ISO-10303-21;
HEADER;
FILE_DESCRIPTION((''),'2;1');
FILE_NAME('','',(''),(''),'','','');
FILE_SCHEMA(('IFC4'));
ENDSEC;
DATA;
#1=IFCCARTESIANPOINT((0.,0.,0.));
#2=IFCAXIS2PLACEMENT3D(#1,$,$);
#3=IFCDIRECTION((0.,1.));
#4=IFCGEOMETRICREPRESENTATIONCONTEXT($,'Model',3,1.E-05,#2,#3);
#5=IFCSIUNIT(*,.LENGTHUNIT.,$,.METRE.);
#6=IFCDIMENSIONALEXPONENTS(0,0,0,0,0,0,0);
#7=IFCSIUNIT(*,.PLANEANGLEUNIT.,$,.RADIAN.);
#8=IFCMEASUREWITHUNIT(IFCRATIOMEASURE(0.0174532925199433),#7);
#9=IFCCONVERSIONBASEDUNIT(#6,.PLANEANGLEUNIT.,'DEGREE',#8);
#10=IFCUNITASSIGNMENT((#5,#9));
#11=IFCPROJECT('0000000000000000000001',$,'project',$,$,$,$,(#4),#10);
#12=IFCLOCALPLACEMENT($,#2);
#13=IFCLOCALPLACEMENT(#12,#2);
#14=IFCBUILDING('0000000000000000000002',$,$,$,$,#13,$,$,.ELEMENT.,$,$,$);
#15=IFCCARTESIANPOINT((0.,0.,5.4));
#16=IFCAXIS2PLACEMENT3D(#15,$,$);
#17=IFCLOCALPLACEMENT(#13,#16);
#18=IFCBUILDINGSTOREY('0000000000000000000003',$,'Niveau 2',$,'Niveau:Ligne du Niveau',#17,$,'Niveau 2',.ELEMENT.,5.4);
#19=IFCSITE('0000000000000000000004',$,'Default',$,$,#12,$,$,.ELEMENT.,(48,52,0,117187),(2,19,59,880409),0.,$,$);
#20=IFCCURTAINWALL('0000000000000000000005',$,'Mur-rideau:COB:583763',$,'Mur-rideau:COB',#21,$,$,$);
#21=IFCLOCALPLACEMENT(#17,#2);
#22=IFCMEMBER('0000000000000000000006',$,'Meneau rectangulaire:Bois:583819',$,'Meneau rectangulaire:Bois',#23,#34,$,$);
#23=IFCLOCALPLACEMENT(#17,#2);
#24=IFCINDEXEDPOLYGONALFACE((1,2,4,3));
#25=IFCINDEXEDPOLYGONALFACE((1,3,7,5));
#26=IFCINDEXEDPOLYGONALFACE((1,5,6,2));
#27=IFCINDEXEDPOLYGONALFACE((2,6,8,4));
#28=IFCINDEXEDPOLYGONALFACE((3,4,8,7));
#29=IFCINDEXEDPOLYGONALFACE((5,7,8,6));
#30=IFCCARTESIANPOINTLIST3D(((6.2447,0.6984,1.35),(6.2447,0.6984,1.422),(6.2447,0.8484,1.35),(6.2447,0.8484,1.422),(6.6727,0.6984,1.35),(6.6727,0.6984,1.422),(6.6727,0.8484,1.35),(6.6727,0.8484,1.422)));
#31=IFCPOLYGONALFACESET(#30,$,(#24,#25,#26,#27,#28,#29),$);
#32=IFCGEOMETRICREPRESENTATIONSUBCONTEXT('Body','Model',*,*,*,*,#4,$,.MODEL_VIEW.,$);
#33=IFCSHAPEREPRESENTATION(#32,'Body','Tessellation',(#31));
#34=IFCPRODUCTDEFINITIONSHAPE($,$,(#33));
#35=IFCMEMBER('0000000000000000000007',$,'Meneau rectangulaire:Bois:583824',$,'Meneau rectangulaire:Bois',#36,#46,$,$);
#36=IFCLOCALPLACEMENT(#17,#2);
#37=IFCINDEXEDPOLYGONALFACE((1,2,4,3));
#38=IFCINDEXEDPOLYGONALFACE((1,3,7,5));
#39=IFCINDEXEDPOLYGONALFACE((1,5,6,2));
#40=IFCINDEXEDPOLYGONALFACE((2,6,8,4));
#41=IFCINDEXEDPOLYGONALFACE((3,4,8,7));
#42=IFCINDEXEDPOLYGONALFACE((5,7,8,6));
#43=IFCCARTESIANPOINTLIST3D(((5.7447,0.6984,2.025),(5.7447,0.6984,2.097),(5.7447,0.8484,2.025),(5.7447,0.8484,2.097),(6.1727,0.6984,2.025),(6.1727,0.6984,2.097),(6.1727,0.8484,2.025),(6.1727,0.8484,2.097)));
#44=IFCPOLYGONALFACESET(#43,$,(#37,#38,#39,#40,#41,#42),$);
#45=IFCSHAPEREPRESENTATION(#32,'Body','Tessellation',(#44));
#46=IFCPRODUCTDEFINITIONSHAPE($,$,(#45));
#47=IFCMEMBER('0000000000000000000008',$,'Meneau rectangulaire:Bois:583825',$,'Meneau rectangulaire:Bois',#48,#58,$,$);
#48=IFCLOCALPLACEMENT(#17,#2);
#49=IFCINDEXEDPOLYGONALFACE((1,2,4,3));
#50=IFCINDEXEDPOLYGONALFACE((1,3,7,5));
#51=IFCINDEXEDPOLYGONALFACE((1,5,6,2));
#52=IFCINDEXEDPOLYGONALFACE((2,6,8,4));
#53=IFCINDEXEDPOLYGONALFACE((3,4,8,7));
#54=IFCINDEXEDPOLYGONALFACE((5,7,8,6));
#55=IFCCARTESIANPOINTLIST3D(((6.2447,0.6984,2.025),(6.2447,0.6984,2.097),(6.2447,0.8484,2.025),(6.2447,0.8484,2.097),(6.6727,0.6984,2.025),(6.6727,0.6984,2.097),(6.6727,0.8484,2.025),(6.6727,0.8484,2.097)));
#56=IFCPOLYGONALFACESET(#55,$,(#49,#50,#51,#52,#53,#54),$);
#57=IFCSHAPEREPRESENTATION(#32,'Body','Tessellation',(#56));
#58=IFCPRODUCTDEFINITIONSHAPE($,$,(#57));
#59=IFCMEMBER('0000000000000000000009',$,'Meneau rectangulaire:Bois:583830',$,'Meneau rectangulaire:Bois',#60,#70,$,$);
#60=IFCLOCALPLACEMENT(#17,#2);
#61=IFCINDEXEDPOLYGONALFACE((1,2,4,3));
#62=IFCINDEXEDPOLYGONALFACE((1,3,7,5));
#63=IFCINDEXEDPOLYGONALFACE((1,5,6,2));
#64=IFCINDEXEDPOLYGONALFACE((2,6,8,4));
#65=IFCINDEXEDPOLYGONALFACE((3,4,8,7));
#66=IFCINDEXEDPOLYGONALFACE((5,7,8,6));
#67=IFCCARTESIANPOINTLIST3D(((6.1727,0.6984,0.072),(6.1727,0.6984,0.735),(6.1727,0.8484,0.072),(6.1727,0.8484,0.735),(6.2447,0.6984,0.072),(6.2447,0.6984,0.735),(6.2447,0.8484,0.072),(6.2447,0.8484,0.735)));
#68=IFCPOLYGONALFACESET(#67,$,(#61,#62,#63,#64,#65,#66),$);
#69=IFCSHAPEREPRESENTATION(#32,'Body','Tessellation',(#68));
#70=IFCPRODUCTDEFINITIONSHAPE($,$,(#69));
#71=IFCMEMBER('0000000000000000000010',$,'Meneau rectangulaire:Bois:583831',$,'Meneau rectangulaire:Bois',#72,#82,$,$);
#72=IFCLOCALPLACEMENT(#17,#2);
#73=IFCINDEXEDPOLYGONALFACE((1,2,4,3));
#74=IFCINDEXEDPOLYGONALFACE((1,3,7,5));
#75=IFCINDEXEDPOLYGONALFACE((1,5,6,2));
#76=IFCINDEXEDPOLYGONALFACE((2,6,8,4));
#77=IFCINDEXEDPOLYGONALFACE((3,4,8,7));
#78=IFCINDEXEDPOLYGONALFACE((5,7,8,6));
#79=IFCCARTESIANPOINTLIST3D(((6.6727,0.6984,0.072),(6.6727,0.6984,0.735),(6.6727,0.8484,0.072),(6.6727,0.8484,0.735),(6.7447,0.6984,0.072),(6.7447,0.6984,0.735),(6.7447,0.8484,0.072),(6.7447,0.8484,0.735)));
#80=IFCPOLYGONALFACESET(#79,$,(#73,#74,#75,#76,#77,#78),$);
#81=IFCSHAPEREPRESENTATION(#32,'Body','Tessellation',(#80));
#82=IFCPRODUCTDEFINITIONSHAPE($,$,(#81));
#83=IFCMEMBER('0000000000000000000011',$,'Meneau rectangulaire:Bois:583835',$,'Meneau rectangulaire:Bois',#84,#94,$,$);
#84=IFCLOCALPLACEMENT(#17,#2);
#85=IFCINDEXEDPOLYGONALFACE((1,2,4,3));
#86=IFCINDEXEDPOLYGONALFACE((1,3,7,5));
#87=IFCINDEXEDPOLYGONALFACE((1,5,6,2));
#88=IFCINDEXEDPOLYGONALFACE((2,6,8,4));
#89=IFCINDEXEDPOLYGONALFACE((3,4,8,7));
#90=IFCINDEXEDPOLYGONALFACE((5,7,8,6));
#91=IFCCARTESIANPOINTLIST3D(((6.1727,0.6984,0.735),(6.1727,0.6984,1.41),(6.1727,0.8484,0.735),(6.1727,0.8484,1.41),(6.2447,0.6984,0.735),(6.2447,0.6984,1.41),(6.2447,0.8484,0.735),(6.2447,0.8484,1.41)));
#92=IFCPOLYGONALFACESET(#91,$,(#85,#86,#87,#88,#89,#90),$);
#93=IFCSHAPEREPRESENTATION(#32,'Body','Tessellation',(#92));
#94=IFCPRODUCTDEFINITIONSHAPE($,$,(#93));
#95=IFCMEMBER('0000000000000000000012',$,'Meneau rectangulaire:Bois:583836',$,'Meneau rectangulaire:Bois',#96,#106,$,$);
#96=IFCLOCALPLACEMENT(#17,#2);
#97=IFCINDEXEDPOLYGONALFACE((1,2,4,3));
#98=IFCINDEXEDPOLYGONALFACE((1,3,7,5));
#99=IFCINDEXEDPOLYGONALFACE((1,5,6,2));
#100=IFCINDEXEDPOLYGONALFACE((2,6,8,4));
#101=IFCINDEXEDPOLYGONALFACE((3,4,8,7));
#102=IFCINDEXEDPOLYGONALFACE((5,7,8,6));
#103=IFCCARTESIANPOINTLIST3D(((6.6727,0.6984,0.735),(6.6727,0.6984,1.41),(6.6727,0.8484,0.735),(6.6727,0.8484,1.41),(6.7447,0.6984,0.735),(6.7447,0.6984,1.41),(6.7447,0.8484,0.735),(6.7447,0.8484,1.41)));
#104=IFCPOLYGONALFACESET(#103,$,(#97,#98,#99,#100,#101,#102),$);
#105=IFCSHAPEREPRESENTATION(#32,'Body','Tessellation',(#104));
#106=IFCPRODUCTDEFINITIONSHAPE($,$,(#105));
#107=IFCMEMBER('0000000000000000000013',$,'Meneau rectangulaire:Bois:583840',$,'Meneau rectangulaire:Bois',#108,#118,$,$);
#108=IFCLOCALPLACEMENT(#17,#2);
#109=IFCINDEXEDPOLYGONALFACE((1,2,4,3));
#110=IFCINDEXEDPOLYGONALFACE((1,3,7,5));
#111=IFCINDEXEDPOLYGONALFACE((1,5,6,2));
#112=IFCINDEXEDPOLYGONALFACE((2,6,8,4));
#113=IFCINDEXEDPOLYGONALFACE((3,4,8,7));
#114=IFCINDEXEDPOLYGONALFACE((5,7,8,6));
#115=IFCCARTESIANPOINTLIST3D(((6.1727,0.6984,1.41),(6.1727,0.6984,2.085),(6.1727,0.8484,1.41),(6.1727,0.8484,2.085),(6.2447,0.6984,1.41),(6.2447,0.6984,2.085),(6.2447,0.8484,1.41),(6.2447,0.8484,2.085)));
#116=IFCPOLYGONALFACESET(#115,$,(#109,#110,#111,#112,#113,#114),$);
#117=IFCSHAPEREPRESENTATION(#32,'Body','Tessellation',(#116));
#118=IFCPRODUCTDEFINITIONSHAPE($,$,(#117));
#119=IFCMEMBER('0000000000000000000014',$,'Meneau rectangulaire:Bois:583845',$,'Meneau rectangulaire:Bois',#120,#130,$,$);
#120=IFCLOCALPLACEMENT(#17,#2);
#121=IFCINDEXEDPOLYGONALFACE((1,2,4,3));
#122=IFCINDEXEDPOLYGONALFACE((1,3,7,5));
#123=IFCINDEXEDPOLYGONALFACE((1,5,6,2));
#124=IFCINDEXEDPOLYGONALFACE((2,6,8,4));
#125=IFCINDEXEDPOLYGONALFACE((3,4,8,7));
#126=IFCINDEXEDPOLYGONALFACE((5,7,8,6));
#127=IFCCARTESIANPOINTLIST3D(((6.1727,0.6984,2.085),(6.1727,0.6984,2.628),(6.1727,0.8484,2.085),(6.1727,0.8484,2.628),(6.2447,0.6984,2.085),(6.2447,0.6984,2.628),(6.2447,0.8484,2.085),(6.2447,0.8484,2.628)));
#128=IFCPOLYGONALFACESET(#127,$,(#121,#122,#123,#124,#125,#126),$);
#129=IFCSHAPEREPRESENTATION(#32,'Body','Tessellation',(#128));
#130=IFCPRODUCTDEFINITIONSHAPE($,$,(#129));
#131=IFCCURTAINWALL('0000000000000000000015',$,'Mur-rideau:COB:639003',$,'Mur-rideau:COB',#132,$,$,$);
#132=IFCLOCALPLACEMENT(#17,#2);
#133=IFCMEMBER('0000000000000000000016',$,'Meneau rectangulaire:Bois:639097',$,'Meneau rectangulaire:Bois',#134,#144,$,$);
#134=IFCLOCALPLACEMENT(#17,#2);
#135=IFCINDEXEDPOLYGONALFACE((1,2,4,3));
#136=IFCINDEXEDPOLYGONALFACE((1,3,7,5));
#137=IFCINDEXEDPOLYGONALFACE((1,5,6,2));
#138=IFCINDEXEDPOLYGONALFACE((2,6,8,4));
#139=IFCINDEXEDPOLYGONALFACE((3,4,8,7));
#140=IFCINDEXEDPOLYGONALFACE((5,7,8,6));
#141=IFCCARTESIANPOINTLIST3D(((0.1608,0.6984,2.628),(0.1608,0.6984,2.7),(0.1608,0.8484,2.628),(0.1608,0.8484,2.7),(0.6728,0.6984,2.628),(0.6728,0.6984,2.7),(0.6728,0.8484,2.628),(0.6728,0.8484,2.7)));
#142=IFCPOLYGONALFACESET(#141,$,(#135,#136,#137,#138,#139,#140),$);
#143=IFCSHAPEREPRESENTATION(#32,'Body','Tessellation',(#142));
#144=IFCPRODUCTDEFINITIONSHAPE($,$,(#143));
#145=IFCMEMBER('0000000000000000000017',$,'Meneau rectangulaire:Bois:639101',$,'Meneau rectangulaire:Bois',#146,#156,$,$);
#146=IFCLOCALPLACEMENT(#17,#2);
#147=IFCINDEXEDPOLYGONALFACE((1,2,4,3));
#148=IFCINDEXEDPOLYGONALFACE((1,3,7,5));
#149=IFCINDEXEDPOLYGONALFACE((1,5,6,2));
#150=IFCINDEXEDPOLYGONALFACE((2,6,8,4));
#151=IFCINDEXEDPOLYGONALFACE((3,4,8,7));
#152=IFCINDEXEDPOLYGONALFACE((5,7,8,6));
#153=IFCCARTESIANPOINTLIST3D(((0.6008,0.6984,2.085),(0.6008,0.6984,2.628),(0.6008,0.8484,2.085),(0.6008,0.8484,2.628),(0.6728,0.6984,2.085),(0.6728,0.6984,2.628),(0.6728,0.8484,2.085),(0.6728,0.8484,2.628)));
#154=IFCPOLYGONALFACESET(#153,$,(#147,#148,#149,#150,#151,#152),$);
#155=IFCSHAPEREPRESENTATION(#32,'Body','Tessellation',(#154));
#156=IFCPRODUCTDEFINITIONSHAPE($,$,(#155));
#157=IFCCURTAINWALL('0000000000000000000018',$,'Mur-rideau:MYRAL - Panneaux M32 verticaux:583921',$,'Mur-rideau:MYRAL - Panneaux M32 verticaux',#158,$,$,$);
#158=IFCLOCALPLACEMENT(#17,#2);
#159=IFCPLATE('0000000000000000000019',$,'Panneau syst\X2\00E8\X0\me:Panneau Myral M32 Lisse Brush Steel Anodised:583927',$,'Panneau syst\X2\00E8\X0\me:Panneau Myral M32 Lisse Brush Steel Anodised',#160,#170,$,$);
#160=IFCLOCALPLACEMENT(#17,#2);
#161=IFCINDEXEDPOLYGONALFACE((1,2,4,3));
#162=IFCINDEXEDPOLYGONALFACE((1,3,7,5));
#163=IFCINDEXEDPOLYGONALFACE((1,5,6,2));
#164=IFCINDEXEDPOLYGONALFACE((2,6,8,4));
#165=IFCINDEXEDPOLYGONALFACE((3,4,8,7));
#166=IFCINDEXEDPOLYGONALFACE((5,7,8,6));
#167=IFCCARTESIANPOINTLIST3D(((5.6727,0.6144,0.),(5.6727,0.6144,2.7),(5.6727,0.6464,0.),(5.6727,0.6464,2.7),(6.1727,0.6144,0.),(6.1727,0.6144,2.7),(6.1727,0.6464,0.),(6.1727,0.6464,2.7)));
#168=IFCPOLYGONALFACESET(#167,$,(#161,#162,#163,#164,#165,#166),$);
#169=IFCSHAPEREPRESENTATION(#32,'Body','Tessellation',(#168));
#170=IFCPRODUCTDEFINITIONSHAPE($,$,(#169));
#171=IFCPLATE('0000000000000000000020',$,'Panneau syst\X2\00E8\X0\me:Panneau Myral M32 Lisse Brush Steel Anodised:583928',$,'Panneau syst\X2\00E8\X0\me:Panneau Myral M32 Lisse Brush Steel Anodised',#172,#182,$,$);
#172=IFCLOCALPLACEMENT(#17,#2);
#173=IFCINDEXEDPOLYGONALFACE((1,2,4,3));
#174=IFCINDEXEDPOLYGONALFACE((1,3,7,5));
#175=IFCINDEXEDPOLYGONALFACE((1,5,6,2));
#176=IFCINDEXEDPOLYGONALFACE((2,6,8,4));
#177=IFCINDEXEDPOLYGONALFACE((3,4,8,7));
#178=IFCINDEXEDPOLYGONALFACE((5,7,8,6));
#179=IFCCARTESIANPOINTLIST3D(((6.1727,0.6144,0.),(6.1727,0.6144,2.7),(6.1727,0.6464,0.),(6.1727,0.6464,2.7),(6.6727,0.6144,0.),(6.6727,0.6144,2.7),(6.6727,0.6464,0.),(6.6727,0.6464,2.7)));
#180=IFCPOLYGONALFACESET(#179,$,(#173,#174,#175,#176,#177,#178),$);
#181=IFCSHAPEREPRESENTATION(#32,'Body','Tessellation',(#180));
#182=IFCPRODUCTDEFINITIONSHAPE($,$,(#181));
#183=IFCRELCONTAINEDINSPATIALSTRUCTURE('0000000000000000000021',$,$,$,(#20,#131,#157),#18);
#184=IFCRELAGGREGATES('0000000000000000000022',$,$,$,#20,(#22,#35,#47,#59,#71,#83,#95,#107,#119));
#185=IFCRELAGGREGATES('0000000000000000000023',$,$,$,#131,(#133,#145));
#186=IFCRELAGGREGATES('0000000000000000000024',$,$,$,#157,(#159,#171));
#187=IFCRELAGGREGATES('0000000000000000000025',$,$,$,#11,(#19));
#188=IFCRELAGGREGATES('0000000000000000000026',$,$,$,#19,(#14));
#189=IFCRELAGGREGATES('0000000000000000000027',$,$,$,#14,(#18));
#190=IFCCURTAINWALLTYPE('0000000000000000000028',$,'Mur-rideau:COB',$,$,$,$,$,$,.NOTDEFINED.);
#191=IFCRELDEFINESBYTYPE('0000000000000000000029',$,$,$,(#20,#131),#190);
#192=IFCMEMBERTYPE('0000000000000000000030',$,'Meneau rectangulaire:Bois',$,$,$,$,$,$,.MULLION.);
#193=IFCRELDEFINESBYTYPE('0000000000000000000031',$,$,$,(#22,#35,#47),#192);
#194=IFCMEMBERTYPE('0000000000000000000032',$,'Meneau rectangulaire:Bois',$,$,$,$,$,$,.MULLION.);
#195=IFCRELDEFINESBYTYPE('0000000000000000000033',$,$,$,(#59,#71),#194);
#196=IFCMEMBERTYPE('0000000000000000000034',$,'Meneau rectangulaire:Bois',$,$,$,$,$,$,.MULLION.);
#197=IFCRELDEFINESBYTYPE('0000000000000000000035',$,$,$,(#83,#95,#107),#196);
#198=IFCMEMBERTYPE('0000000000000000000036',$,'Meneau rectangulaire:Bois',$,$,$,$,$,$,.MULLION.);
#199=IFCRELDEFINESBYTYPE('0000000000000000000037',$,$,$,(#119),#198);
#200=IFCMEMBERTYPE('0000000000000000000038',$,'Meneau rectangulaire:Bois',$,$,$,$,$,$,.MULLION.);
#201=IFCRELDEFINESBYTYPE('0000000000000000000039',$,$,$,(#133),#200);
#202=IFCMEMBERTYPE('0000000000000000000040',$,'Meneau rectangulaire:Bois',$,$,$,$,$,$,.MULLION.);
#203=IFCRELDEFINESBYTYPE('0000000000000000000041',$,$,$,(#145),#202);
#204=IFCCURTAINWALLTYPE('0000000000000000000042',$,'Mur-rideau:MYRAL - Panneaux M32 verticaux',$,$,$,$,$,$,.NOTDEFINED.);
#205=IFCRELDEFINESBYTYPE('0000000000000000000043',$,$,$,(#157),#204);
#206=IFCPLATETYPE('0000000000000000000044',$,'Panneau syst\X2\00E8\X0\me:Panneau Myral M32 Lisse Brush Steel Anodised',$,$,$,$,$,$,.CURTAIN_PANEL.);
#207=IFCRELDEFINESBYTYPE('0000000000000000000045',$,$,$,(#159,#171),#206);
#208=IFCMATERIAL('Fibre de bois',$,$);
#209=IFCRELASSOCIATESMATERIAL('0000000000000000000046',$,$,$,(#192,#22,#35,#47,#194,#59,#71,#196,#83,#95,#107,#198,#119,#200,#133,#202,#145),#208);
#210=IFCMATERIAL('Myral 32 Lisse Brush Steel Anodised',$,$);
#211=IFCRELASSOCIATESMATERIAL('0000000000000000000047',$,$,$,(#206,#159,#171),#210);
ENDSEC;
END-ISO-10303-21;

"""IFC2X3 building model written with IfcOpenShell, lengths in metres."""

from ifc_helpers import new_model, entity, si_unit, converted_unit, direction, frame, origin, origin_2d_with_axis, place, context, subcontext, project, spatial, rectangle, extrude, source, transform, mapped, material, type_object, type_shapes, element, aggregate, save


model = new_model("IFC2X3")

# Units and contexts
model_context = context("Model", 3, precision=1e-05, world=origin(), true_north=direction((0.0, 1.0)))
body_context = subcontext(model_context, "Body", "Model", "MODEL_VIEW")
ifc_project = project(units=[si_unit("LENGTHUNIT", "METRE"), converted_unit("PLANEANGLEUNIT", "DEGREE", entity("IfcRatioMeasure", 0.0174532925199433), si_unit("PLANEANGLEUNIT", "RADIAN"), dimensions=[0, 0, 0, 0, 0, 0, 0])], contexts=[model_context])

# Site, building, storey
site_placement = place(None, origin())
site = spatial("IfcSite", under=ifc_project, at=site_placement, Name="Default", CompositionType="ELEMENT", RefLatitude=(48, 52, 0, 117187), RefLongitude=(2, 19, 59, 880409), RefElevation=0.0)
building_placement = place(site_placement, origin())
building = spatial("IfcBuilding", under=site, at=building_placement, CompositionType="ELEMENT")
storey_placement = place(building_placement, frame((0.0, 0.0, 5.4)))
storey = spatial("IfcBuildingStorey", under=building, at=storey_placement, Name="Niveau 2", ObjectType="Niveau:Ligne du Niveau", LongName="Niveau 2", CompositionType="ELEMENT", Elevation=5.4)

# Curtain walls, members
curtain_wall_type_1 = type_object("IfcCurtainWallType", Name="Mur-rideau:COB", PredefinedType="NOTDEFINED")
curtain_wall_1_placement = place(storey_placement, frame((0.0, 0.0, -5.4)))
curtain_wall_1 = element("IfcCurtainWall", 1, at=curtain_wall_1_placement, inside=storey, type_object=curtain_wall_type_1, Name="Mur-rideau:COB:583763", ObjectType="Mur-rideau:COB")
ifc_material_1 = material(Name="Fibre de bois")
member_type_1 = type_object("IfcMemberType", Name="Meneau rectangulaire:Bois", PredefinedType="MULLION", material=ifc_material_1)
shared_shape_1 = source(origin(), body_context, "Body", "SweptSolid", [
    extrude(rectangle(XDim=0.15, YDim=0.072, at=origin_2d_with_axis()), frame((-0.024, 0.0, -0.428), z_axis=(0.0, 0.0, 1.0), x_axis=(0.0, -1.0, 0.0)), (0.0, 0.0, 1.0), 0.428),
])
type_shapes(member_type_1, [shared_shape_1])
member_1_placement = place(storey_placement, frame((6.6727, 0.7734, 1.41), z_axis=(1.0, 0.0, 0.0), x_axis=(0.0, 0.0, 1.0)))
member_1 = element("IfcMember", 2, at=member_1_placement, type_object=member_type_1, material=ifc_material_1, Name="Meneau rectangulaire:Bois:583819", ObjectType="Meneau rectangulaire:Bois", context=body_context, shape_type="MappedRepresentation", body=[
    mapped(shared_shape_1, transform((0.0, 0.0, 0.0), scale=1.0)),
])
member_2_placement = place(storey_placement, frame((6.1727, 0.7734, 2.085), z_axis=(1.0, 0.0, 0.0), x_axis=(0.0, 0.0, 1.0)))
member_2 = element("IfcMember", 3, at=member_2_placement, type_object=member_type_1, material=ifc_material_1, Name="Meneau rectangulaire:Bois:583824", ObjectType="Meneau rectangulaire:Bois", context=body_context, shape_type="MappedRepresentation", body=[
    mapped(shared_shape_1, transform((0.0, 0.0, 0.0), scale=1.0)),
])
member_3_placement = place(storey_placement, frame((6.6727, 0.7734, 2.085), z_axis=(1.0, 0.0, 0.0), x_axis=(0.0, 0.0, 1.0)))
member_3 = element("IfcMember", 4, at=member_3_placement, type_object=member_type_1, material=ifc_material_1, Name="Meneau rectangulaire:Bois:583825", ObjectType="Meneau rectangulaire:Bois", context=body_context, shape_type="MappedRepresentation", body=[
    mapped(shared_shape_1, transform((0.0, 0.0, 0.0), scale=1.0)),
])
member_type_2 = type_object("IfcMemberType", Name="Meneau rectangulaire:Bois", PredefinedType="MULLION", material=ifc_material_1)
shared_shape_2 = source(origin(), body_context, "Body", "SweptSolid", [
    extrude(rectangle(XDim=0.15, YDim=0.072, at=origin_2d_with_axis()), frame((-0.024, 0.0, -0.663), z_axis=(0.0, 0.0, 1.0), x_axis=(0.0, -1.0, 0.0)), (0.0, 0.0, 1.0), 0.663),
])
type_shapes(member_type_2, [shared_shape_2])
member_4_placement = place(storey_placement, frame((6.2327, 0.7734, 0.072), z_axis=(0.0, 0.0, -1.0), x_axis=(1.0, 0.0, 0.0)))
member_4 = element("IfcMember", 5, at=member_4_placement, type_object=member_type_2, material=ifc_material_1, Name="Meneau rectangulaire:Bois:583830", ObjectType="Meneau rectangulaire:Bois", context=body_context, shape_type="MappedRepresentation", body=[
    mapped(shared_shape_2, transform((0.0, 0.0, 0.0), scale=1.0)),
])
member_5_placement = place(storey_placement, frame((6.7327, 0.7734, 0.072), z_axis=(0.0, 0.0, -1.0), x_axis=(1.0, 0.0, 0.0)))
member_5 = element("IfcMember", 6, at=member_5_placement, type_object=member_type_2, material=ifc_material_1, Name="Meneau rectangulaire:Bois:583831", ObjectType="Meneau rectangulaire:Bois", context=body_context, shape_type="MappedRepresentation", body=[
    mapped(shared_shape_2, transform((0.0, 0.0, 0.0), scale=1.0)),
])
member_type_3 = type_object("IfcMemberType", Name="Meneau rectangulaire:Bois", PredefinedType="MULLION", material=ifc_material_1)
shared_shape_3 = source(origin(), body_context, "Body", "SweptSolid", [
    extrude(rectangle(XDim=0.15, YDim=0.072, at=origin_2d_with_axis()), frame((-0.024, 0.0, -0.675), z_axis=(0.0, 0.0, 1.0), x_axis=(0.0, -1.0, 0.0)), (0.0, 0.0, 1.0), 0.675),
])
type_shapes(member_type_3, [shared_shape_3])
member_6_placement = place(storey_placement, frame((6.2327, 0.7734, 0.735), z_axis=(0.0, 0.0, -1.0), x_axis=(1.0, 0.0, 0.0)))
member_6 = element("IfcMember", 7, at=member_6_placement, type_object=member_type_3, material=ifc_material_1, Name="Meneau rectangulaire:Bois:583835", ObjectType="Meneau rectangulaire:Bois", context=body_context, shape_type="MappedRepresentation", body=[
    mapped(shared_shape_3, transform((0.0, 0.0, 0.0), scale=1.0)),
])
member_7_placement = place(storey_placement, frame((6.7327, 0.7734, 0.735), z_axis=(0.0, 0.0, -1.0), x_axis=(1.0, 0.0, 0.0)))
member_7 = element("IfcMember", 8, at=member_7_placement, type_object=member_type_3, material=ifc_material_1, Name="Meneau rectangulaire:Bois:583836", ObjectType="Meneau rectangulaire:Bois", context=body_context, shape_type="MappedRepresentation", body=[
    mapped(shared_shape_3, transform((0.0, 0.0, 0.0), scale=1.0)),
])
member_8_placement = place(storey_placement, frame((6.2327, 0.7734, 1.41), z_axis=(0.0, 0.0, -1.0), x_axis=(1.0, 0.0, 0.0)))
member_8 = element("IfcMember", 9, at=member_8_placement, type_object=member_type_3, material=ifc_material_1, Name="Meneau rectangulaire:Bois:583840", ObjectType="Meneau rectangulaire:Bois", context=body_context, shape_type="MappedRepresentation", body=[
    mapped(shared_shape_3, transform((0.0, 0.0, 0.0), scale=1.0)),
])
member_type_4 = type_object("IfcMemberType", Name="Meneau rectangulaire:Bois", PredefinedType="MULLION", material=ifc_material_1)
shared_shape_4 = source(origin(), body_context, "Body", "SweptSolid", [
    extrude(rectangle(XDim=0.15, YDim=0.072, at=origin_2d_with_axis()), frame((-0.024, 0.0, -0.543), z_axis=(0.0, 0.0, 1.0), x_axis=(0.0, -1.0, 0.0)), (0.0, 0.0, 1.0), 0.543),
])
type_shapes(member_type_4, [shared_shape_4])
member_9_placement = place(storey_placement, frame((6.2327, 0.7734, 2.085), z_axis=(0.0, 0.0, -1.0), x_axis=(1.0, 0.0, 0.0)))
member_9 = element("IfcMember", 10, at=member_9_placement, type_object=member_type_4, material=ifc_material_1, Name="Meneau rectangulaire:Bois:583845", ObjectType="Meneau rectangulaire:Bois", context=body_context, shape_type="MappedRepresentation", body=[
    mapped(shared_shape_4, transform((0.0, 0.0, 0.0), scale=1.0)),
])
aggregate(curtain_wall_1, [member_1, member_2, member_3, member_4, member_5, member_6, member_7, member_8, member_9])
curtain_wall_2_placement = place(storey_placement, frame((0.0, 0.0, -5.4)))
curtain_wall_2 = element("IfcCurtainWall", 11, at=curtain_wall_2_placement, inside=storey, type_object=curtain_wall_type_1, Name="Mur-rideau:COB:639003", ObjectType="Mur-rideau:COB")
member_type_5 = type_object("IfcMemberType", Name="Meneau rectangulaire:Bois", PredefinedType="MULLION", material=ifc_material_1)
shared_shape_5 = source(origin(), body_context, "Body", "SweptSolid", [
    extrude(rectangle(XDim=0.15, YDim=0.072, at=origin_2d_with_axis()), frame((-0.036, 0.0, -0.512), z_axis=(0.0, 0.0, 1.0), x_axis=(0.0, -1.0, 0.0)), (0.0, 0.0, 1.0), 0.512),
])
type_shapes(member_type_5, [shared_shape_5])
member_10_placement = place(storey_placement, frame((0.6728, 0.7734, 2.7), z_axis=(1.0, 0.0, 0.0), x_axis=(0.0, 0.0, 1.0)))
member_10 = element("IfcMember", 12, at=member_10_placement, type_object=member_type_5, material=ifc_material_1, Name="Meneau rectangulaire:Bois:639097", ObjectType="Meneau rectangulaire:Bois", context=body_context, shape_type="MappedRepresentation", body=[
    mapped(shared_shape_5, transform((0.0, 0.0, 0.0), scale=1.0)),
])
member_type_6 = type_object("IfcMemberType", Name="Meneau rectangulaire:Bois", PredefinedType="MULLION", material=ifc_material_1)
shared_shape_6 = source(origin(), body_context, "Body", "SweptSolid", [
    extrude(rectangle(XDim=0.15, YDim=0.072, at=origin_2d_with_axis()), frame((-0.024, 0.0, -0.543), z_axis=(0.0, 0.0, 1.0), x_axis=(0.0, -1.0, 0.0)), (0.0, 0.0, 1.0), 0.543),
])
type_shapes(member_type_6, [shared_shape_6])
member_11_placement = place(storey_placement, frame((0.6608, 0.7734, 2.085), z_axis=(0.0, 0.0, -1.0), x_axis=(1.0, 0.0, 0.0)))
member_11 = element("IfcMember", 13, at=member_11_placement, type_object=member_type_6, material=ifc_material_1, Name="Meneau rectangulaire:Bois:639101", ObjectType="Meneau rectangulaire:Bois", context=body_context, shape_type="MappedRepresentation", body=[
    mapped(shared_shape_6, transform((0.0, 0.0, 0.0), scale=1.0)),
])
aggregate(curtain_wall_2, [member_10, member_11])

# Curtain wall, plates
curtain_wall_type_2 = type_object("IfcCurtainWallType", Name="Mur-rideau:MYRAL - Panneaux M32 verticaux", PredefinedType="NOTDEFINED")
curtain_wall_3_placement = place(storey_placement, frame((0.0, 0.0, -5.4)))
curtain_wall_3 = element("IfcCurtainWall", 14, at=curtain_wall_3_placement, inside=storey, type_object=curtain_wall_type_2, Name="Mur-rideau:MYRAL - Panneaux M32 verticaux:583921", ObjectType="Mur-rideau:MYRAL - Panneaux M32 verticaux")
ifc_material_2 = material(Name="Myral 32 Lisse Brush Steel Anodised")
plate_type = type_object("IfcPlateType", Name="Panneau système:Panneau Myral M32 Lisse Brush Steel Anodised", PredefinedType="CURTAIN_PANEL", material=ifc_material_2)
shared_shape_7 = source(origin(), body_context, "Body", "SweptSolid", [
    extrude(rectangle(XDim=0.032, YDim=0.5, at=origin_2d_with_axis()), frame((0.0, -0.016, 0.0), z_axis=(0.0, 0.0, 1.0), x_axis=(0.0, 1.0, 0.0)), (0.0, 0.0, 1.0), 2.7),
])
type_shapes(plate_type, [shared_shape_7])
plate_1_placement = place(curtain_wall_3_placement, frame((5.9227, 0.6464, 5.4)))
plate_1 = element("IfcPlate", 15, at=plate_1_placement, type_object=plate_type, material=ifc_material_2, Name="Panneau système:Panneau Myral M32 Lisse Brush Steel Anodised:583927", ObjectType="Panneau système:Panneau Myral M32 Lisse Brush Steel Anodised", context=body_context, shape_type="MappedRepresentation", body=[
    mapped(shared_shape_7, transform((0.0, 0.0, 0.0), scale=1.0)),
])
plate_2_placement = place(curtain_wall_3_placement, frame((6.4227, 0.6464, 5.4)))
plate_2 = element("IfcPlate", 16, at=plate_2_placement, type_object=plate_type, material=ifc_material_2, Name="Panneau système:Panneau Myral M32 Lisse Brush Steel Anodised:583928", ObjectType="Panneau système:Panneau Myral M32 Lisse Brush Steel Anodised", context=body_context, shape_type="MappedRepresentation", body=[
    mapped(shared_shape_7, transform((0.0, 0.0, 0.0), scale=1.0)),
])
aggregate(curtain_wall_3, [plate_1, plate_2])

save(model, "model.ifc")
